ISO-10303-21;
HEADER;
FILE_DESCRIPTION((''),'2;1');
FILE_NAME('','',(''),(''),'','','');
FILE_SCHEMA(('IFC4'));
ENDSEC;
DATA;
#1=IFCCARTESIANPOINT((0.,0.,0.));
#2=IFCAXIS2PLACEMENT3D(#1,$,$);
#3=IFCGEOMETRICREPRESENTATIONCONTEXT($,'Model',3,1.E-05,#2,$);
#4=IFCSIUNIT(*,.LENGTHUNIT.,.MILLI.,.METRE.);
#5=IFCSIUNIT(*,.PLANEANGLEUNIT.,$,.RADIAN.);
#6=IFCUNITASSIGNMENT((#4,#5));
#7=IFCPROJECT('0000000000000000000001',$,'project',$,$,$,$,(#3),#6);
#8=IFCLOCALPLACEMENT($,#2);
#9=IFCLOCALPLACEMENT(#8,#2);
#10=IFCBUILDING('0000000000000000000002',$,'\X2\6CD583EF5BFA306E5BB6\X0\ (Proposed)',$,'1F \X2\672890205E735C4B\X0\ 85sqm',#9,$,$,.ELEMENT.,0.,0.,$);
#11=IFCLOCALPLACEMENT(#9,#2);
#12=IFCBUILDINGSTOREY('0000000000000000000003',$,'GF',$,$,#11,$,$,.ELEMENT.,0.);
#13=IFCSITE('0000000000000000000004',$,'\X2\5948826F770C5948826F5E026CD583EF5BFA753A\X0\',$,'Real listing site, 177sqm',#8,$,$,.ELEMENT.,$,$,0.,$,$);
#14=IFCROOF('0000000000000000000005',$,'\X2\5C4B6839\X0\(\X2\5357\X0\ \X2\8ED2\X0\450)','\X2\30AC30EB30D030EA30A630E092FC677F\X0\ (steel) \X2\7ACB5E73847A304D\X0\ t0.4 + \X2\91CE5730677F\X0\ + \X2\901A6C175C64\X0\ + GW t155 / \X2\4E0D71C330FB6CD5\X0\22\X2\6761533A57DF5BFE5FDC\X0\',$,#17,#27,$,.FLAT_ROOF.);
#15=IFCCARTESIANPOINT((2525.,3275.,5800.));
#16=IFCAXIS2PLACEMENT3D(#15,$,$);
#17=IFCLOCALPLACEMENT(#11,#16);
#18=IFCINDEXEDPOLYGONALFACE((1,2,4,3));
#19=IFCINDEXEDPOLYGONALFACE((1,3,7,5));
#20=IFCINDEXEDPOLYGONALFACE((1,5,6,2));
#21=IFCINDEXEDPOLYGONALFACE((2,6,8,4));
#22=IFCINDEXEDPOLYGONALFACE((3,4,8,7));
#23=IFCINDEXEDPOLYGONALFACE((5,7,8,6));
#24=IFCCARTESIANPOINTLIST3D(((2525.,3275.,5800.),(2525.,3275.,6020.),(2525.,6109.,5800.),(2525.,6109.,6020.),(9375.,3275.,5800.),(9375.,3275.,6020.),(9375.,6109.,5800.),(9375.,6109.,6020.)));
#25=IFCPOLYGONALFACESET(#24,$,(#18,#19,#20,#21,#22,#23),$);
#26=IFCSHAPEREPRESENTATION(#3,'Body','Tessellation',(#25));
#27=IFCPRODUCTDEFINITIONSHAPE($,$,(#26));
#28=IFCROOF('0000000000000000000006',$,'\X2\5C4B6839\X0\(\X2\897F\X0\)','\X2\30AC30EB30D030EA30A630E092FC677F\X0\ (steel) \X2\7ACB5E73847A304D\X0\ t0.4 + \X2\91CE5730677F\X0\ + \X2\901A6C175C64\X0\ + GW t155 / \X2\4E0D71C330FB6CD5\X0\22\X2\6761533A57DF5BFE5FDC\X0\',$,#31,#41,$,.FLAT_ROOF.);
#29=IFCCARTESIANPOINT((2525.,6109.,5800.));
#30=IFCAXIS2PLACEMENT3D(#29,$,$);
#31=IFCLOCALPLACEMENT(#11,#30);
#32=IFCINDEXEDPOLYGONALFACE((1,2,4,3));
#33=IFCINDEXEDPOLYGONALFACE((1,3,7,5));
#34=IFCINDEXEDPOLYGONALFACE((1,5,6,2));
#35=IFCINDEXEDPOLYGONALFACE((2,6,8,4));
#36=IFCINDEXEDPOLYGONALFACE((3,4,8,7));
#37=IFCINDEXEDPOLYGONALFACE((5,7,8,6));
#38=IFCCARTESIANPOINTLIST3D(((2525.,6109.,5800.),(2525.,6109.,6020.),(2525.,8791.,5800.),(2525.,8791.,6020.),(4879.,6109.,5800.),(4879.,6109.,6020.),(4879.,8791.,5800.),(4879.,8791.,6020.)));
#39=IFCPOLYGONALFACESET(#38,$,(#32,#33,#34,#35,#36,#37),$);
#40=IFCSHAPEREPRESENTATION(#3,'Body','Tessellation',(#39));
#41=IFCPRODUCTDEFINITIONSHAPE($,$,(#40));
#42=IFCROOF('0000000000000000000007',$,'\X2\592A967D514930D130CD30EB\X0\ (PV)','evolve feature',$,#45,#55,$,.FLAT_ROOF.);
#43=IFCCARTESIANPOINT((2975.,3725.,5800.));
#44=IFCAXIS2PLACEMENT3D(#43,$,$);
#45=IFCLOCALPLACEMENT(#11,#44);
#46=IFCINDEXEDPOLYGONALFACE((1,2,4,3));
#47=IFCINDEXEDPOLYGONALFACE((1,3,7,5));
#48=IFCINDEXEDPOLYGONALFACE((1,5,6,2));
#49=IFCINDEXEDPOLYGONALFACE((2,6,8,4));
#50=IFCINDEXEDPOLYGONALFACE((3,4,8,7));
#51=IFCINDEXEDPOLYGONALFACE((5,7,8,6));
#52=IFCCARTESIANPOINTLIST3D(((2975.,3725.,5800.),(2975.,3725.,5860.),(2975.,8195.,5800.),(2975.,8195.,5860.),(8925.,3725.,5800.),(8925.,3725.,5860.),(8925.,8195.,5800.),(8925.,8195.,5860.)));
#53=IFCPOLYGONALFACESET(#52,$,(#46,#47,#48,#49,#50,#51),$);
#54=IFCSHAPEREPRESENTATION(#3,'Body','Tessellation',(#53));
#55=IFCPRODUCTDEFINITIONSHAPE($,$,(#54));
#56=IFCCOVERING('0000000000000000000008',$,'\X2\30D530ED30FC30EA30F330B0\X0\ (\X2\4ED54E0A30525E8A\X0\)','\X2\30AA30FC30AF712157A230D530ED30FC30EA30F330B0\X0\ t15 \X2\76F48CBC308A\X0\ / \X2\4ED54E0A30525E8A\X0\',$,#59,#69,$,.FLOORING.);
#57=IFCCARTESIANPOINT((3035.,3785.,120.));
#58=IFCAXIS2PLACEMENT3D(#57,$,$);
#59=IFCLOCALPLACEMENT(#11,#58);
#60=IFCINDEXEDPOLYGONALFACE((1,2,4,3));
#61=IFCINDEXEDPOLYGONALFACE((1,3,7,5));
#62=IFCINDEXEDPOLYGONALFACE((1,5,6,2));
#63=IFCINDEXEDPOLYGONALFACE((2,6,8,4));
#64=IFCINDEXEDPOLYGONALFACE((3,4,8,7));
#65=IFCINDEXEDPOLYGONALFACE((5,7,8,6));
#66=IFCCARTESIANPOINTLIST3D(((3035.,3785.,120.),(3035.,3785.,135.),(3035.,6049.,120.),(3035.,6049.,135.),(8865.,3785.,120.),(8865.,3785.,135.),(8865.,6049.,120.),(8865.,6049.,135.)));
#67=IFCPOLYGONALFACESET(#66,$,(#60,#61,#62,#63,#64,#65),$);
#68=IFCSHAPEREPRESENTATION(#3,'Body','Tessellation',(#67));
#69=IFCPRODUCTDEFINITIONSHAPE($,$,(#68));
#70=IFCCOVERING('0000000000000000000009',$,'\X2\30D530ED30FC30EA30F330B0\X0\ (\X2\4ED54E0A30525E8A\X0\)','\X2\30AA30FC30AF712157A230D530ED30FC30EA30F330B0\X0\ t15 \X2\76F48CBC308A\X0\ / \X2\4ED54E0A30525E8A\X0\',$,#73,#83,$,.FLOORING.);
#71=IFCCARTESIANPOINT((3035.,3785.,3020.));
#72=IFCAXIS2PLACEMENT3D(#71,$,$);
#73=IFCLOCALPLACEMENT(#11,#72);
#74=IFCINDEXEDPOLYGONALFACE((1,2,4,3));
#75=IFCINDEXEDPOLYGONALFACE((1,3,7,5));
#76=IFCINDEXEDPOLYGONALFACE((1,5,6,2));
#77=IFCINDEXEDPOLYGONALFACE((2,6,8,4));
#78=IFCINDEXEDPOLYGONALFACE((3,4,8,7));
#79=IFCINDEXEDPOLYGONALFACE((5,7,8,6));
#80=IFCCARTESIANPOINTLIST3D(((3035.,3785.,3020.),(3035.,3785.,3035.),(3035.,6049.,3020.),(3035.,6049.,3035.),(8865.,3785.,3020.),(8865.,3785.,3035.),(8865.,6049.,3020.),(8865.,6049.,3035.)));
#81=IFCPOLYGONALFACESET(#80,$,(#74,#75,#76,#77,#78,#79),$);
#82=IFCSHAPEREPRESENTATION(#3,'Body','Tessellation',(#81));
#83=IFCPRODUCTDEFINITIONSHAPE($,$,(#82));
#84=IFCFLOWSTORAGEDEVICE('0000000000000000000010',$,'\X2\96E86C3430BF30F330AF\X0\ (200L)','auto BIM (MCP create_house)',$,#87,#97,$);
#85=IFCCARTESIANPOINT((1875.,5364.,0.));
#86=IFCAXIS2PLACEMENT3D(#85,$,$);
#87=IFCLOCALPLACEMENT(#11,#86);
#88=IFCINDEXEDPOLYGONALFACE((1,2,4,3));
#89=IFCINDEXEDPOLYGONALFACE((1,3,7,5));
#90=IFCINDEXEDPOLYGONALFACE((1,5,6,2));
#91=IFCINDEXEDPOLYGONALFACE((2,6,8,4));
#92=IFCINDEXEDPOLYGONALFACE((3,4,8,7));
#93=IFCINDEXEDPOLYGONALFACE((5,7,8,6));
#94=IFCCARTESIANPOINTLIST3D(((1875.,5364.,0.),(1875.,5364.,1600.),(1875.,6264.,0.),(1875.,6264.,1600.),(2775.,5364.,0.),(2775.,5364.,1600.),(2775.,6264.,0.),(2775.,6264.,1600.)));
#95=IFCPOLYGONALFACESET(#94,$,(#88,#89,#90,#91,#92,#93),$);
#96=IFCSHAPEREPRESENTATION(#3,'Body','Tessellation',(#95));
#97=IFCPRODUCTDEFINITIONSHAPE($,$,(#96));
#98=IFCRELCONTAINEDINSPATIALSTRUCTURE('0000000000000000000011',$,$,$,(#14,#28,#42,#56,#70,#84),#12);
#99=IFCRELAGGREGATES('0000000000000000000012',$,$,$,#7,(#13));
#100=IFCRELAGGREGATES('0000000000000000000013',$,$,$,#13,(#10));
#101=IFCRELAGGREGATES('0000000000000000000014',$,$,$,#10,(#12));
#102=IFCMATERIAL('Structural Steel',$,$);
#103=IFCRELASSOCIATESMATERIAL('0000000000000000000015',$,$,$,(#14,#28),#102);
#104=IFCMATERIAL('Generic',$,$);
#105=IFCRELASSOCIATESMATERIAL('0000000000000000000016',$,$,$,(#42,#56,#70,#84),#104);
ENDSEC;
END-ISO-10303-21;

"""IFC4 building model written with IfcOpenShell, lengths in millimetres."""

from ifc_helpers import new_model, si_unit, frame, frame_2d, origin, place, context, project, spatial, rectangle, extrude, material, element, save


model = new_model("IFC4")

# Units and contexts
model_context = context("Model", 3, precision=1e-05, world=origin())
ifc_project = project(units=[si_unit("LENGTHUNIT", "METRE", prefix="MILLI"), si_unit("PLANEANGLEUNIT", "RADIAN")], contexts=[model_context])

# Site, building, storey
site_placement = place(None, origin())
site = spatial("IfcSite", under=ifc_project, at=site_placement, Name="奈良県奈良市法華寺町", ObjectType="Real listing site, 177sqm", CompositionType="ELEMENT", RefElevation=0.0)
building_placement = place(site_placement, origin())
building = spatial("IfcBuilding", under=site, at=building_placement, Name="法華寺の家 (Proposed)", ObjectType="1F 木造平屋 85sqm", CompositionType="ELEMENT", ElevationOfRefHeight=0.0, ElevationOfTerrain=0.0)
storey_placement = place(building_placement, origin())
storey = spatial("IfcBuildingStorey", under=building, at=storey_placement, Name="GF", CompositionType="ELEMENT", Elevation=0.0)

# Shared definitions
ifc_material_1 = material(Name="Generic")

# Roofs
ifc_material_2 = material(Name="Structural Steel")
roof_1_placement = place(storey_placement, frame((2525.0, 3275.0, 5800.0)))
element("IfcRoof", 1, at=roof_1_placement, inside=storey, material=ifc_material_2, Name="屋根(南 軒450)", Description="ガルバリウム鋼板 (steel) 立平葺き t0.4 + 野地板 + 通気層 + GW t155 / 不燃・法22条区域対応", PredefinedType="FLAT_ROOF", context=model_context, shape_type="SweptSolid", body=[
    extrude(rectangle(XDim=6850.0, YDim=2834.0, at=frame_2d((3425.0, 1417.0))), frame((2525.0, 3275.0, 5800.0)), (0.0, 0.0, 1.0), 220.0),
])
roof_2_placement = place(storey_placement, frame((2525.0, 6109.0, 5800.0)))
element("IfcRoof", 2, at=roof_2_placement, inside=storey, material=ifc_material_2, Name="屋根(西)", Description="ガルバリウム鋼板 (steel) 立平葺き t0.4 + 野地板 + 通気層 + GW t155 / 不燃・法22条区域対応", PredefinedType="FLAT_ROOF", context=model_context, shape_type="SweptSolid", body=[
    extrude(rectangle(XDim=2354.0, YDim=2682.0, at=frame_2d((1177.0, 1341.0))), frame((2525.0, 6109.0, 5800.0)), (0.0, 0.0, 1.0), 220.0),
])
roof_3_placement = place(storey_placement, frame((2975.0, 3725.0, 5800.0)))
element("IfcRoof", 3, at=roof_3_placement, inside=storey, material=ifc_material_1, Name="太陽光パネル (PV)", Description="evolve feature", PredefinedType="FLAT_ROOF", context=model_context, shape_type="SweptSolid", body=[
    extrude(rectangle(XDim=5950.0, YDim=4470.0, at=frame_2d((2975.0, 2235.0))), frame((2975.0, 3725.0, 5800.0)), (0.0, 0.0, 1.0), 60.0),
])

# Coverings
covering_1_placement = place(storey_placement, frame((3035.0, 3785.0, 120.0)))
element("IfcCovering", 4, at=covering_1_placement, inside=storey, material=ifc_material_1, Name="フローリング (仕上げ床)", Description="オーク無垢フローリング t15 直貼り / 仕上げ床", PredefinedType="FLOORING", context=model_context, shape_type="SweptSolid", body=[
    extrude(rectangle(XDim=5830.0, YDim=2264.0, at=frame_2d((2915.0, 1132.0))), frame((3035.0, 3785.0, 120.0)), (0.0, 0.0, 1.0), 15.0),
])
covering_2_placement = place(storey_placement, frame((3035.0, 3785.0, 3020.0)))
element("IfcCovering", 5, at=covering_2_placement, inside=storey, material=ifc_material_1, Name="フローリング (仕上げ床)", Description="オーク無垢フローリング t15 直貼り / 仕上げ床", PredefinedType="FLOORING", context=model_context, shape_type="SweptSolid", body=[
    extrude(rectangle(XDim=5830.0, YDim=2264.0, at=frame_2d((2915.0, 1132.0))), frame((3035.0, 3785.0, 3020.0)), (0.0, 0.0, 1.0), 15.0),
])

# Flow storage device
flow_storage_device_placement = place(storey_placement, frame((1875.0, 5364.0, 0.0)))
element("IfcFlowStorageDevice", 6, at=flow_storage_device_placement, inside=storey, material=ifc_material_1, Name="雨水タンク (200L)", Description="auto BIM (MCP create_house)", context=model_context, shape_type="SweptSolid", body=[
    extrude(rectangle(XDim=900.0, YDim=900.0, at=frame_2d((450.0, 450.0))), frame((1875.0, 5364.0, 0.0)), (0.0, 0.0, 1.0), 1600.0),
])

save(model, "model.ifc")
